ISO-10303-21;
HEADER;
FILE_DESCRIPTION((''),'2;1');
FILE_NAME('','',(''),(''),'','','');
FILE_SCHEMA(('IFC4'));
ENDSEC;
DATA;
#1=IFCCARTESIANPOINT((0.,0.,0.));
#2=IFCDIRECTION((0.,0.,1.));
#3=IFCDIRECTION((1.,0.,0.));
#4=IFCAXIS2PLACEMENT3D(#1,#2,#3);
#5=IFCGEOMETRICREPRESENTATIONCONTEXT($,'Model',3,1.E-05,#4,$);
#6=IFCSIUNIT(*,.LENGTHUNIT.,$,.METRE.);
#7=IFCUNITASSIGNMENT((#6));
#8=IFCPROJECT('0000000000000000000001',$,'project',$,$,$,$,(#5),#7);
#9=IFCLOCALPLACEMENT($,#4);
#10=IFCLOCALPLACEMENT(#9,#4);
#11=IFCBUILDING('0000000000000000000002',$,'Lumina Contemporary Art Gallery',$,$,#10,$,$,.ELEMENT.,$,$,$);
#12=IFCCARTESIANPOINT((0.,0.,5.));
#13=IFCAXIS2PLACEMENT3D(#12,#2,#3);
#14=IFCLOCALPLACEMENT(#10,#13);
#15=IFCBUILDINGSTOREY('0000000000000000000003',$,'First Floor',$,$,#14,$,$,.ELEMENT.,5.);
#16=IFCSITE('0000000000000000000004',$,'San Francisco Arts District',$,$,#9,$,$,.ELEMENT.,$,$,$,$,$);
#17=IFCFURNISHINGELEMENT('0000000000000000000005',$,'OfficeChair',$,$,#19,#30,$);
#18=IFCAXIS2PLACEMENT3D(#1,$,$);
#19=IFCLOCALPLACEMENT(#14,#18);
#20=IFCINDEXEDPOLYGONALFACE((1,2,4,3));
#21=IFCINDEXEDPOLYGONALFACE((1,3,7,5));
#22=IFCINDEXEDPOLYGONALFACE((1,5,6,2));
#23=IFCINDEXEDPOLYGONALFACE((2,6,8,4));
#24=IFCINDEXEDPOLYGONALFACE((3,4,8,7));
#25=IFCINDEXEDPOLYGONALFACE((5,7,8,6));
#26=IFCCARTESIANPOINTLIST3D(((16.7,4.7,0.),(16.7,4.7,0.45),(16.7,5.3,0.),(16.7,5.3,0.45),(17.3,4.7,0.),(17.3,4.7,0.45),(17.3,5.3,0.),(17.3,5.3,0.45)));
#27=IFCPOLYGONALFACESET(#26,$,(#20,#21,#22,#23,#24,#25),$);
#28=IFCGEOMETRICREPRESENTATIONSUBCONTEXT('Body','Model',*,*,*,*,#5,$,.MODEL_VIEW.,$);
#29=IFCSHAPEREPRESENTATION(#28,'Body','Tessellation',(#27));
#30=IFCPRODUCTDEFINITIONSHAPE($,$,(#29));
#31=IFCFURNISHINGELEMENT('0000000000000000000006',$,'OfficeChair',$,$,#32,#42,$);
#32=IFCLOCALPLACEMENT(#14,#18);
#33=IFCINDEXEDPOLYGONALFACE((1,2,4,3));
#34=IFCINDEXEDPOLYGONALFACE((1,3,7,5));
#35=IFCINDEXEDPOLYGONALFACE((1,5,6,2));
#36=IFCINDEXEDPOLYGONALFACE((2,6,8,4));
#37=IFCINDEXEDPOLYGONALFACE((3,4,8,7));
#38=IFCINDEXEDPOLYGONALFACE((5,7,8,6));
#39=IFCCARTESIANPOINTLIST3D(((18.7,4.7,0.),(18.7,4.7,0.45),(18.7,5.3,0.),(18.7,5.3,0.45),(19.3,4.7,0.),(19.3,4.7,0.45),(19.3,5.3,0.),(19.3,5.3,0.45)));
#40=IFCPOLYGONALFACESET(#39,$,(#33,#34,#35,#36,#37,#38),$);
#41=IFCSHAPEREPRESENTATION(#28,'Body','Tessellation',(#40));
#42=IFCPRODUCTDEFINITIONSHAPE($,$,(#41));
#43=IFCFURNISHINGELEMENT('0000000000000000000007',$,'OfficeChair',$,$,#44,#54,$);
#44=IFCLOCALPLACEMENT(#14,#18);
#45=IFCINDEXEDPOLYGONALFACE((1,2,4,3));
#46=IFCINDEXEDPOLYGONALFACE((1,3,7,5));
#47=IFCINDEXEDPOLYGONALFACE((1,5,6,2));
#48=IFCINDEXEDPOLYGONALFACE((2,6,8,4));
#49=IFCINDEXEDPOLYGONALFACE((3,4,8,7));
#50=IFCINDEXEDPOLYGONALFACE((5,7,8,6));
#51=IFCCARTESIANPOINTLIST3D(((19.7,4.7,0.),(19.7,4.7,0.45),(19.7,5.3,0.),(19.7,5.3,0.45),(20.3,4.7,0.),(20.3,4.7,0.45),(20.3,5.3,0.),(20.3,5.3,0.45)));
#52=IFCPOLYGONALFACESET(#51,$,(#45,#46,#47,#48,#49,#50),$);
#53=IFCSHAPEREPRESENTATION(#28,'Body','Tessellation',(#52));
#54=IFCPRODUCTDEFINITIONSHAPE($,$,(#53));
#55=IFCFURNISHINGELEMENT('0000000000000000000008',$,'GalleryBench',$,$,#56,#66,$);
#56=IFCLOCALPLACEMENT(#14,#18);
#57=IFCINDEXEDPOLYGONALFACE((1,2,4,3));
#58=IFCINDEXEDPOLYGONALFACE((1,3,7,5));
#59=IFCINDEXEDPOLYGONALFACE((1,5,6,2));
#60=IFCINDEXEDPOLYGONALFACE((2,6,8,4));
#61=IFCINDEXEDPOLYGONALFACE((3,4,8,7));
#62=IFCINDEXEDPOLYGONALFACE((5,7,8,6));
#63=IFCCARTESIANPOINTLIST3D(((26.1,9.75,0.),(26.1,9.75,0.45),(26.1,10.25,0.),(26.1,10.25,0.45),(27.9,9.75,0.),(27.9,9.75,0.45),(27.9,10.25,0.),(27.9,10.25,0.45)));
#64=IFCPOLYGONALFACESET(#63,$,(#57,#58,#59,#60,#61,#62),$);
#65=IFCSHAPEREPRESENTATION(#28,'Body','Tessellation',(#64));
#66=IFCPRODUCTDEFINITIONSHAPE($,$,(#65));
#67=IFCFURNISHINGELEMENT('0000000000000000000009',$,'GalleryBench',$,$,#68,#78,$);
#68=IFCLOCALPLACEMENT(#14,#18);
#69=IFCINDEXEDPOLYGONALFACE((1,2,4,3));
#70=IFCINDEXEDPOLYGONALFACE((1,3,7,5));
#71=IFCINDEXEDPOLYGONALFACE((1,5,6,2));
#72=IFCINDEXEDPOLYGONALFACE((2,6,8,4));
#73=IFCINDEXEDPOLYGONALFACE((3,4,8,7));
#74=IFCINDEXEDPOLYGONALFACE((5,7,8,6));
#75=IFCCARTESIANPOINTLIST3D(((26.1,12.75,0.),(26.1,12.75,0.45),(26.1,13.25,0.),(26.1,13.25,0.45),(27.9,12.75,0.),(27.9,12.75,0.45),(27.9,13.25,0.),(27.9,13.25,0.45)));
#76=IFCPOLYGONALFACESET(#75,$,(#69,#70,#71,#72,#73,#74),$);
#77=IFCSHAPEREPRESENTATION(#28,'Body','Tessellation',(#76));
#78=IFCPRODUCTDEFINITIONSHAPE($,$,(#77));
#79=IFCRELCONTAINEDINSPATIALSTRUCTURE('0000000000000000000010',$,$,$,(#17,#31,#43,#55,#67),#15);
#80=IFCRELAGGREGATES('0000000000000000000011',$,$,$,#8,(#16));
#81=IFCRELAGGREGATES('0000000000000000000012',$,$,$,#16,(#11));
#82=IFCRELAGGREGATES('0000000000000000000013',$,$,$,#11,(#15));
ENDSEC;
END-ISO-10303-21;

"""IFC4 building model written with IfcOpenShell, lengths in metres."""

from ifc_helpers import new_model, si_unit, frame, origin_with_axes, place, context, subcontext, project, spatial, polyline, outline, extrude, element, save


model = new_model("IFC4")

# Units and contexts
model_context = context("Model", 3, precision=1e-05, world=origin_with_axes())
body_context = subcontext(model_context, "Body", "Model", "MODEL_VIEW")
ifc_project = project(units=[si_unit("LENGTHUNIT", "METRE")], contexts=[model_context])

# Site, building, storey
site_placement = place(None, origin_with_axes())
site = spatial("IfcSite", under=ifc_project, at=site_placement, Name="San Francisco Arts District", CompositionType="ELEMENT")
building_placement = place(site_placement, origin_with_axes())
building = spatial("IfcBuilding", under=site, at=building_placement, Name="Lumina Contemporary Art Gallery", CompositionType="ELEMENT")
storey_placement = place(building_placement, frame((0.0, 0.0, 5.0), z_axis=(0.0, 0.0, 1.0), x_axis=(1.0, 0.0, 0.0)))
storey = spatial("IfcBuildingStorey", under=building, at=storey_placement, Name="First Floor", CompositionType="ELEMENT", Elevation=5.0)

# Furnishing elements
furnishing_1_placement = place(storey_placement, origin_with_axes())
element("IfcFurnishingElement", 1, at=furnishing_1_placement, inside=storey, Name="OfficeChair", context=body_context, shape_type="SweptSolid", body=[
    extrude(outline(polyline([(17.3, 5.3, 0.0), (16.7, 5.3, 0.0), (16.7, 4.7, 0.0), (17.3, 4.7, 0.0), (17.3, 5.3, 0.0)])), None, (0.0, 0.0, 1.0), 0.45),
])
furnishing_2_placement = place(storey_placement, origin_with_axes())
element("IfcFurnishingElement", 2, at=furnishing_2_placement, inside=storey, Name="OfficeChair", context=body_context, shape_type="SweptSolid", body=[
    extrude(outline(polyline([(19.3, 5.3, 0.0), (18.7, 5.3, 0.0), (18.7, 4.7, 0.0), (19.3, 4.7, 0.0), (19.3, 5.3, 0.0)])), None, (0.0, 0.0, 1.0), 0.45),
])
furnishing_3_placement = place(storey_placement, origin_with_axes())
element("IfcFurnishingElement", 3, at=furnishing_3_placement, inside=storey, Name="OfficeChair", context=body_context, shape_type="SweptSolid", body=[
    extrude(outline(polyline([(20.3, 5.3, 0.0), (19.7, 5.3, 0.0), (19.7, 4.7, 0.0), (20.3, 4.7, 0.0), (20.3, 5.3, 0.0)])), None, (0.0, 0.0, 1.0), 0.45),
])
furnishing_4_placement = place(storey_placement, origin_with_axes())
element("IfcFurnishingElement", 4, at=furnishing_4_placement, inside=storey, Name="GalleryBench", context=body_context, shape_type="SweptSolid", body=[
    extrude(outline(polyline([(26.1, 9.75, 0.0), (27.9, 9.75, 0.0), (27.9, 10.25, 0.0), (26.1, 10.25, 0.0), (26.1, 9.75, 0.0)])), None, (0.0, 0.0, 1.0), 0.45),
])
furnishing_5_placement = place(storey_placement, origin_with_axes())
element("IfcFurnishingElement", 5, at=furnishing_5_placement, inside=storey, Name="GalleryBench", context=body_context, shape_type="SweptSolid", body=[
    extrude(outline(polyline([(27.9, 13.25, 0.0), (26.1, 13.25, 0.0), (26.1, 12.75, 0.0), (27.9, 12.75, 0.0), (27.9, 13.25, 0.0)])), None, (0.0, 0.0, 1.0), 0.45),
])

save(model, "model.ifc")
